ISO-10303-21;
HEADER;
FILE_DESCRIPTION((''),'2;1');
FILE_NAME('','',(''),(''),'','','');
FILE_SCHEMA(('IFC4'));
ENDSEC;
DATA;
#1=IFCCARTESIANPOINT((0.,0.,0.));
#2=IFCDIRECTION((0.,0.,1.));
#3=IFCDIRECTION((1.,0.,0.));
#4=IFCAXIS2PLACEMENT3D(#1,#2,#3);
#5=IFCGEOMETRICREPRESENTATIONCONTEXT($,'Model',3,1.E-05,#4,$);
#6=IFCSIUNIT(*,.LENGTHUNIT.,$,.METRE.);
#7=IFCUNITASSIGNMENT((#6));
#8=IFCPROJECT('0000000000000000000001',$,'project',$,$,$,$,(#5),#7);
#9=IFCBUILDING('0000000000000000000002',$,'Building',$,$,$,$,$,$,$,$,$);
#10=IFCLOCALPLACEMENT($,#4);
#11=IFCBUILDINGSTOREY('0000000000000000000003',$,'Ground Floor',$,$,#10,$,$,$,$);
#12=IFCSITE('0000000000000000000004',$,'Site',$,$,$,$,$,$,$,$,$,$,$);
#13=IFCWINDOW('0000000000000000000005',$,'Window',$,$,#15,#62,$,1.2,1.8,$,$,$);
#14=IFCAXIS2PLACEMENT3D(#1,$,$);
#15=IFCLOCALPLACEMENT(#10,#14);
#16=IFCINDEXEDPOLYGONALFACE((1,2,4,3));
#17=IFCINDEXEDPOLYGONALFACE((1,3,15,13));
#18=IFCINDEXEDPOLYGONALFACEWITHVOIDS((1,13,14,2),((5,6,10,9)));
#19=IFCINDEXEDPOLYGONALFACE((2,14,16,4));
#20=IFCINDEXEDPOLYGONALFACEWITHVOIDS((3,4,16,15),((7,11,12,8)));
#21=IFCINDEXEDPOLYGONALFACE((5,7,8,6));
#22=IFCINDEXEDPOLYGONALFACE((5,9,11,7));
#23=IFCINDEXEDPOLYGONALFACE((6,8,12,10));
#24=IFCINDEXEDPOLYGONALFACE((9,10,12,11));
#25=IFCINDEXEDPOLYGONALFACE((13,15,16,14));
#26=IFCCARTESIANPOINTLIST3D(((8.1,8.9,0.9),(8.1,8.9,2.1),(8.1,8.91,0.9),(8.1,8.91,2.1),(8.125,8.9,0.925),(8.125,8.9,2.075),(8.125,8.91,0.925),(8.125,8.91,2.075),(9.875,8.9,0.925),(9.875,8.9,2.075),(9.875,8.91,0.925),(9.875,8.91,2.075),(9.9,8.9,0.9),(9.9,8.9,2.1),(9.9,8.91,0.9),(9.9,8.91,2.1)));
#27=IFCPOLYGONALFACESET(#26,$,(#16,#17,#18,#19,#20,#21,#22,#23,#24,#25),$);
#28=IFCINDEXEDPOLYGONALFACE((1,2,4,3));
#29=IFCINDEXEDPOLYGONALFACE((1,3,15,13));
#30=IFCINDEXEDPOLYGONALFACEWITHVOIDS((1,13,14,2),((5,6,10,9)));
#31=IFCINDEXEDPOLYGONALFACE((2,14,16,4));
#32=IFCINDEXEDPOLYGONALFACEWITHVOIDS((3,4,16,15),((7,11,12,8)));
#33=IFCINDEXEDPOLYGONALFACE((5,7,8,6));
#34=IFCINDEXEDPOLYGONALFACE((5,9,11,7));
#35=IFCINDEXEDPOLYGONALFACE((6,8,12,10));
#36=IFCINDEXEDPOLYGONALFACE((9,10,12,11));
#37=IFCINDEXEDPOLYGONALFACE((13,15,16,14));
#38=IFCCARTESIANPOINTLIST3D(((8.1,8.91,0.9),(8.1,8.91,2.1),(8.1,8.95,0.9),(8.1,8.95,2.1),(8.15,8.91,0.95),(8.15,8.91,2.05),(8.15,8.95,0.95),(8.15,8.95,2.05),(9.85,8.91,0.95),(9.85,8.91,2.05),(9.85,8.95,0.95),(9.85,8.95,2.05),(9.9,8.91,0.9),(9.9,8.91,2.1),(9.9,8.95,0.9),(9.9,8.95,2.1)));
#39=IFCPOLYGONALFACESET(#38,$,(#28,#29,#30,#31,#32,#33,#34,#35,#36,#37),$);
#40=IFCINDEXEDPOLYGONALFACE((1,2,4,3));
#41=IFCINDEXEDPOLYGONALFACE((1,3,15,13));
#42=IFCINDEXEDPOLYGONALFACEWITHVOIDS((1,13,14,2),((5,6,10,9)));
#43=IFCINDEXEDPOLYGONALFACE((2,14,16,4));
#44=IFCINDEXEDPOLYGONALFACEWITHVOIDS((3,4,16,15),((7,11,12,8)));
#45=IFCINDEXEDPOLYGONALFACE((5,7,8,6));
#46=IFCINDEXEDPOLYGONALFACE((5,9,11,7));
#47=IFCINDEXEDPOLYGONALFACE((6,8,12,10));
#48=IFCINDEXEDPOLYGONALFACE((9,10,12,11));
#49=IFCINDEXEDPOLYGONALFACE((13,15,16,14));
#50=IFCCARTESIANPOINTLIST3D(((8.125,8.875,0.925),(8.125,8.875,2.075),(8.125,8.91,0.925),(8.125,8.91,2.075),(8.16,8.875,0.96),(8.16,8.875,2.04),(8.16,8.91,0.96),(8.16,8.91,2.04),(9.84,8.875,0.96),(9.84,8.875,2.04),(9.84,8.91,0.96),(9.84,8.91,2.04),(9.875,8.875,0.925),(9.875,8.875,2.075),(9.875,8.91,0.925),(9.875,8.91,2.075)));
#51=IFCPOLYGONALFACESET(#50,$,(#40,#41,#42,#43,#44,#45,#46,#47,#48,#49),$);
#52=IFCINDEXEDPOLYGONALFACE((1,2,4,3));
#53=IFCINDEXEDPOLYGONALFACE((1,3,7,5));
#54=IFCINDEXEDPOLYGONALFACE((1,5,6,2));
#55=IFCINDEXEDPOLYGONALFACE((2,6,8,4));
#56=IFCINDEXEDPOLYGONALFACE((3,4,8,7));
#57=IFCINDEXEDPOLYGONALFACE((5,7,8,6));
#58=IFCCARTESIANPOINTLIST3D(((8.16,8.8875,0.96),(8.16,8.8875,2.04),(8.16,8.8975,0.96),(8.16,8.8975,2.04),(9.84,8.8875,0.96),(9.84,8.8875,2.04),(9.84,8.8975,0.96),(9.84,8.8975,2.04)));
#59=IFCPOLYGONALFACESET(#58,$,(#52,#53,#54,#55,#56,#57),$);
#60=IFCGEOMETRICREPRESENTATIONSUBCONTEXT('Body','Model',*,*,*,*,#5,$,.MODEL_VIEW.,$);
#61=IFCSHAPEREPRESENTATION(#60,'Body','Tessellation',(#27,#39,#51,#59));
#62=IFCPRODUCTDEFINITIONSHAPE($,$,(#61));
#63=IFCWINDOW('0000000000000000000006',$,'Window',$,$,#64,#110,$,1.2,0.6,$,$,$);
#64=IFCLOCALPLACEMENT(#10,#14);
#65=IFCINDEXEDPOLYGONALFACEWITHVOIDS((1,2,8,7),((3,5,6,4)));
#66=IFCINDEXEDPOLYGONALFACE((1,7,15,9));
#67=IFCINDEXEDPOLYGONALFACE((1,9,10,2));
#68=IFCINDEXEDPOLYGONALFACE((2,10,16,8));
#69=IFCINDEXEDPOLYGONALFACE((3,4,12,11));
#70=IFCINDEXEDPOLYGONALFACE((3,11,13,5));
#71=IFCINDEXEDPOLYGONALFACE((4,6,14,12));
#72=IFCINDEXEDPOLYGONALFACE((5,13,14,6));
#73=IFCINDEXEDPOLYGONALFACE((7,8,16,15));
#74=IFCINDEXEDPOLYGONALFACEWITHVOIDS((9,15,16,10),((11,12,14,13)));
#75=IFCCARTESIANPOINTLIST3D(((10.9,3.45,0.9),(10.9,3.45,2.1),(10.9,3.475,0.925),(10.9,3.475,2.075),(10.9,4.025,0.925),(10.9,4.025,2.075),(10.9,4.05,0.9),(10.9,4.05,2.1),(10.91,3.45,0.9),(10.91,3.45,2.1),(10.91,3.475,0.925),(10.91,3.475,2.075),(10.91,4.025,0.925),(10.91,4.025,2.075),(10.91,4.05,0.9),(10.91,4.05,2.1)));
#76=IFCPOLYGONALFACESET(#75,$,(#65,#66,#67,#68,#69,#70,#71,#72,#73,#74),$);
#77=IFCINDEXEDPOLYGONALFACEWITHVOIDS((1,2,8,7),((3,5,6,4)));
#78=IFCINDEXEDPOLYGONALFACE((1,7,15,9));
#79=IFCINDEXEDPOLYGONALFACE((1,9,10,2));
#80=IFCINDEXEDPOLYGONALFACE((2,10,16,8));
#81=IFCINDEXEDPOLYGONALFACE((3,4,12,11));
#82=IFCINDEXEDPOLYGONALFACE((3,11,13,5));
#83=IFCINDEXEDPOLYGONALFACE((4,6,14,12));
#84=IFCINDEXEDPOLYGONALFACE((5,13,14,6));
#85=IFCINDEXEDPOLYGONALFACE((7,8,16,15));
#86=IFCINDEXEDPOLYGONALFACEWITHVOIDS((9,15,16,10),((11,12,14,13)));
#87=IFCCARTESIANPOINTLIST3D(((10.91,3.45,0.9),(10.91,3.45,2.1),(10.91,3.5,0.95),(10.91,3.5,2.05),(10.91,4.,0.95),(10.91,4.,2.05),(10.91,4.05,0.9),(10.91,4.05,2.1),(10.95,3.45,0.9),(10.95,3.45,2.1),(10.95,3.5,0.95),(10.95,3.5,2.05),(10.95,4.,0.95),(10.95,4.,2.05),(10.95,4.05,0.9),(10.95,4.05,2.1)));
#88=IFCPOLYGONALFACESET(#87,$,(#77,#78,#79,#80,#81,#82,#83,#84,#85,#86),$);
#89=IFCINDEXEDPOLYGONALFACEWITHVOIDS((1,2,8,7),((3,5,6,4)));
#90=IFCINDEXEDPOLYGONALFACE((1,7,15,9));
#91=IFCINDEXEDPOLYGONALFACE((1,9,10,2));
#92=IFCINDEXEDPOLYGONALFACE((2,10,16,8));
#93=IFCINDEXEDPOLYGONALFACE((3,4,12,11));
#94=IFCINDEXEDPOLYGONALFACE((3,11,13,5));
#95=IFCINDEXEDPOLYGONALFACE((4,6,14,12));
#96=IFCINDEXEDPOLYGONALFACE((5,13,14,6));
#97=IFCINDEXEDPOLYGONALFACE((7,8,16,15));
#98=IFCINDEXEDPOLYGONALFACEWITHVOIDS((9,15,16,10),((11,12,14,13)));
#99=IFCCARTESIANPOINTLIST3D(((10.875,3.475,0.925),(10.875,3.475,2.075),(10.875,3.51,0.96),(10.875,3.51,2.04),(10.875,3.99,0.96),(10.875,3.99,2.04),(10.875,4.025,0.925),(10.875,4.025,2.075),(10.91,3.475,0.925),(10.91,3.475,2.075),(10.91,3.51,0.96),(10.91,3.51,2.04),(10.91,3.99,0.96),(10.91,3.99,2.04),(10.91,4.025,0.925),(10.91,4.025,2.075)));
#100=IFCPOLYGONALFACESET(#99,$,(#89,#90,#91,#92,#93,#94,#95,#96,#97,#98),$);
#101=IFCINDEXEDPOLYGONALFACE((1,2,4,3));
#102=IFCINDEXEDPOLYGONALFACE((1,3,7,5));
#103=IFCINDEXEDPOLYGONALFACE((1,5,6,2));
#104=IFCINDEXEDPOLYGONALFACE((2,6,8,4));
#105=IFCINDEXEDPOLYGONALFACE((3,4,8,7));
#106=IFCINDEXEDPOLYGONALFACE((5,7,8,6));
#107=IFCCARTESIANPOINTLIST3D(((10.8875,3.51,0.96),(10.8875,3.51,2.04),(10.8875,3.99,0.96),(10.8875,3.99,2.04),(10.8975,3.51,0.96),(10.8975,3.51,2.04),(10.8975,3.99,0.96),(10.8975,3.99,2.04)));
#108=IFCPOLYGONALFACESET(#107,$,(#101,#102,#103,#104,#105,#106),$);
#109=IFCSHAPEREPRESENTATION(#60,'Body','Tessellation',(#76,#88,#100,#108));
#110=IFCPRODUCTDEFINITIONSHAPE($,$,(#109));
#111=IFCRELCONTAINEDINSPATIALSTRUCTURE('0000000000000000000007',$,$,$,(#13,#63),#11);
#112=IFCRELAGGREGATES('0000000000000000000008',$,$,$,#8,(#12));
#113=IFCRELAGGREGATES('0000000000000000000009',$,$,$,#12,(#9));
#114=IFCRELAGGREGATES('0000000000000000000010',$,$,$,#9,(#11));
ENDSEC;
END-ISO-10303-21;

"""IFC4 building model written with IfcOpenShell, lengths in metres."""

from ifc_helpers import new_model, si_unit, frame, origin_with_axes, place, context, subcontext, project, spatial, line, indexed_curve, outline, extrude, element, save


model = new_model("IFC4")

# Units and contexts
model_context = context("Model", 3, precision=1e-05, world=origin_with_axes())
body_context = subcontext(model_context, "Body", "Model", "MODEL_VIEW")
ifc_project = project(units=[si_unit("LENGTHUNIT", "METRE")], contexts=[model_context])

# Site, building, storey
site = spatial("IfcSite", under=ifc_project, Name="Site")
building = spatial("IfcBuilding", under=site, Name="Building")
storey_placement = place(None, origin_with_axes())
storey = spatial("IfcBuildingStorey", under=building, at=storey_placement, Name="Ground Floor")

# Windows
window_1_placement = place(storey_placement, frame((9.9, 9.0, 0.9), z_axis=(0.0, 0.0, 1.0), x_axis=(-1.0, 0.0, 0.0)))
element("IfcWindow", 1, at=window_1_placement, inside=storey, Name="Window", OverallHeight=1.2, OverallWidth=1.8, context=body_context, shape_type="SweptSolid", body=[
    extrude(outline(indexed_curve([(0.0, 0.0), (1.8, 0.0), (1.8, 1.2), (0.0, 1.2)], segments=[line(1, 2, 3, 4, 1)]), holes=[indexed_curve([(0.025, 0.025), (1.775, 0.025), (1.775, 1.175), (0.025, 1.175)], segments=[line(1, 2, 3, 4, 1)])]), frame((0.0, 0.09, 0.0), z_axis=(0.0, -1.0, 0.0), x_axis=(1.0, 0.0, 0.0)), (0.0, 0.0, -1.0), 0.01),
    extrude(outline(indexed_curve([(0.0, 0.0), (1.8, 0.0), (1.8, 1.2), (0.0, 1.2)], segments=[line(1, 2, 3, 4, 1)]), holes=[indexed_curve([(0.05, 0.05), (1.75, 0.05), (1.75, 1.15), (0.05, 1.15)], segments=[line(1, 2, 3, 4, 1)])]), frame((0.0, 0.05, 0.0), z_axis=(0.0, -1.0, 0.0), x_axis=(1.0, 0.0, 0.0)), (0.0, 0.0, -1.0), 0.04),
    extrude(outline(indexed_curve([(0.0, 0.0), (1.75, 0.0), (1.75, 1.15), (0.0, 1.15)], segments=[line(1, 2, 3, 4, 1)]), holes=[indexed_curve([(0.035, 0.035), (1.715, 0.035), (1.715, 1.115), (0.035, 1.115)], segments=[line(1, 2, 3, 4, 1)])]), frame((0.025, 0.09, 0.025), z_axis=(0.0, -1.0, 0.0), x_axis=(1.0, 0.0, 0.0)), (0.0, 0.0, -1.0), 0.035),
    extrude(outline(indexed_curve([(0.035, 0.035), (1.715, 0.035), (1.715, 1.115), (0.035, 1.115)], segments=[line(1, 2, 3, 4, 1)])), frame((0.025, 0.1025, 0.025), z_axis=(0.0, -1.0, 0.0), x_axis=(1.0, 0.0, 0.0)), (0.0, 0.0, -1.0), 0.01),
])
window_2_placement = place(storey_placement, frame((11.0, 3.45, 0.9), z_axis=(0.0, 0.0, 1.0), x_axis=(0.0, 1.0, 0.0)))
element("IfcWindow", 2, at=window_2_placement, inside=storey, Name="Window", OverallHeight=1.2, OverallWidth=0.6, context=body_context, shape_type="SweptSolid", body=[
    extrude(outline(indexed_curve([(0.0, 0.0), (0.6, 0.0), (0.6, 1.2), (0.0, 1.2)], segments=[line(1, 2, 3, 4, 1)]), holes=[indexed_curve([(0.025, 0.025), (0.575, 0.025), (0.575, 1.175), (0.025, 1.175)], segments=[line(1, 2, 3, 4, 1)])]), frame((0.0, 0.09, 0.0), z_axis=(0.0, -1.0, 0.0), x_axis=(1.0, 0.0, 0.0)), (0.0, 0.0, -1.0), 0.01),
    extrude(outline(indexed_curve([(0.0, 0.0), (0.6, 0.0), (0.6, 1.2), (0.0, 1.2)], segments=[line(1, 2, 3, 4, 1)]), holes=[indexed_curve([(0.05, 0.05), (0.55, 0.05), (0.55, 1.15), (0.05, 1.15)], segments=[line(1, 2, 3, 4, 1)])]), frame((0.0, 0.05, 0.0), z_axis=(0.0, -1.0, 0.0), x_axis=(1.0, 0.0, 0.0)), (0.0, 0.0, -1.0), 0.04),
    extrude(outline(indexed_curve([(0.0, 0.0), (0.55, 0.0), (0.55, 1.15), (0.0, 1.15)], segments=[line(1, 2, 3, 4, 1)]), holes=[indexed_curve([(0.035, 0.035), (0.515, 0.035), (0.515, 1.115), (0.035, 1.115)], segments=[line(1, 2, 3, 4, 1)])]), frame((0.025, 0.09, 0.025), z_axis=(0.0, -1.0, 0.0), x_axis=(1.0, 0.0, 0.0)), (0.0, 0.0, -1.0), 0.035),
    extrude(outline(indexed_curve([(0.035, 0.035), (0.515, 0.035), (0.515, 1.115), (0.035, 1.115)], segments=[line(1, 2, 3, 4, 1)])), frame((0.025, 0.1025, 0.025), z_axis=(0.0, -1.0, 0.0), x_axis=(1.0, 0.0, 0.0)), (0.0, 0.0, -1.0), 0.01),
])

save(model, "model.ifc")
